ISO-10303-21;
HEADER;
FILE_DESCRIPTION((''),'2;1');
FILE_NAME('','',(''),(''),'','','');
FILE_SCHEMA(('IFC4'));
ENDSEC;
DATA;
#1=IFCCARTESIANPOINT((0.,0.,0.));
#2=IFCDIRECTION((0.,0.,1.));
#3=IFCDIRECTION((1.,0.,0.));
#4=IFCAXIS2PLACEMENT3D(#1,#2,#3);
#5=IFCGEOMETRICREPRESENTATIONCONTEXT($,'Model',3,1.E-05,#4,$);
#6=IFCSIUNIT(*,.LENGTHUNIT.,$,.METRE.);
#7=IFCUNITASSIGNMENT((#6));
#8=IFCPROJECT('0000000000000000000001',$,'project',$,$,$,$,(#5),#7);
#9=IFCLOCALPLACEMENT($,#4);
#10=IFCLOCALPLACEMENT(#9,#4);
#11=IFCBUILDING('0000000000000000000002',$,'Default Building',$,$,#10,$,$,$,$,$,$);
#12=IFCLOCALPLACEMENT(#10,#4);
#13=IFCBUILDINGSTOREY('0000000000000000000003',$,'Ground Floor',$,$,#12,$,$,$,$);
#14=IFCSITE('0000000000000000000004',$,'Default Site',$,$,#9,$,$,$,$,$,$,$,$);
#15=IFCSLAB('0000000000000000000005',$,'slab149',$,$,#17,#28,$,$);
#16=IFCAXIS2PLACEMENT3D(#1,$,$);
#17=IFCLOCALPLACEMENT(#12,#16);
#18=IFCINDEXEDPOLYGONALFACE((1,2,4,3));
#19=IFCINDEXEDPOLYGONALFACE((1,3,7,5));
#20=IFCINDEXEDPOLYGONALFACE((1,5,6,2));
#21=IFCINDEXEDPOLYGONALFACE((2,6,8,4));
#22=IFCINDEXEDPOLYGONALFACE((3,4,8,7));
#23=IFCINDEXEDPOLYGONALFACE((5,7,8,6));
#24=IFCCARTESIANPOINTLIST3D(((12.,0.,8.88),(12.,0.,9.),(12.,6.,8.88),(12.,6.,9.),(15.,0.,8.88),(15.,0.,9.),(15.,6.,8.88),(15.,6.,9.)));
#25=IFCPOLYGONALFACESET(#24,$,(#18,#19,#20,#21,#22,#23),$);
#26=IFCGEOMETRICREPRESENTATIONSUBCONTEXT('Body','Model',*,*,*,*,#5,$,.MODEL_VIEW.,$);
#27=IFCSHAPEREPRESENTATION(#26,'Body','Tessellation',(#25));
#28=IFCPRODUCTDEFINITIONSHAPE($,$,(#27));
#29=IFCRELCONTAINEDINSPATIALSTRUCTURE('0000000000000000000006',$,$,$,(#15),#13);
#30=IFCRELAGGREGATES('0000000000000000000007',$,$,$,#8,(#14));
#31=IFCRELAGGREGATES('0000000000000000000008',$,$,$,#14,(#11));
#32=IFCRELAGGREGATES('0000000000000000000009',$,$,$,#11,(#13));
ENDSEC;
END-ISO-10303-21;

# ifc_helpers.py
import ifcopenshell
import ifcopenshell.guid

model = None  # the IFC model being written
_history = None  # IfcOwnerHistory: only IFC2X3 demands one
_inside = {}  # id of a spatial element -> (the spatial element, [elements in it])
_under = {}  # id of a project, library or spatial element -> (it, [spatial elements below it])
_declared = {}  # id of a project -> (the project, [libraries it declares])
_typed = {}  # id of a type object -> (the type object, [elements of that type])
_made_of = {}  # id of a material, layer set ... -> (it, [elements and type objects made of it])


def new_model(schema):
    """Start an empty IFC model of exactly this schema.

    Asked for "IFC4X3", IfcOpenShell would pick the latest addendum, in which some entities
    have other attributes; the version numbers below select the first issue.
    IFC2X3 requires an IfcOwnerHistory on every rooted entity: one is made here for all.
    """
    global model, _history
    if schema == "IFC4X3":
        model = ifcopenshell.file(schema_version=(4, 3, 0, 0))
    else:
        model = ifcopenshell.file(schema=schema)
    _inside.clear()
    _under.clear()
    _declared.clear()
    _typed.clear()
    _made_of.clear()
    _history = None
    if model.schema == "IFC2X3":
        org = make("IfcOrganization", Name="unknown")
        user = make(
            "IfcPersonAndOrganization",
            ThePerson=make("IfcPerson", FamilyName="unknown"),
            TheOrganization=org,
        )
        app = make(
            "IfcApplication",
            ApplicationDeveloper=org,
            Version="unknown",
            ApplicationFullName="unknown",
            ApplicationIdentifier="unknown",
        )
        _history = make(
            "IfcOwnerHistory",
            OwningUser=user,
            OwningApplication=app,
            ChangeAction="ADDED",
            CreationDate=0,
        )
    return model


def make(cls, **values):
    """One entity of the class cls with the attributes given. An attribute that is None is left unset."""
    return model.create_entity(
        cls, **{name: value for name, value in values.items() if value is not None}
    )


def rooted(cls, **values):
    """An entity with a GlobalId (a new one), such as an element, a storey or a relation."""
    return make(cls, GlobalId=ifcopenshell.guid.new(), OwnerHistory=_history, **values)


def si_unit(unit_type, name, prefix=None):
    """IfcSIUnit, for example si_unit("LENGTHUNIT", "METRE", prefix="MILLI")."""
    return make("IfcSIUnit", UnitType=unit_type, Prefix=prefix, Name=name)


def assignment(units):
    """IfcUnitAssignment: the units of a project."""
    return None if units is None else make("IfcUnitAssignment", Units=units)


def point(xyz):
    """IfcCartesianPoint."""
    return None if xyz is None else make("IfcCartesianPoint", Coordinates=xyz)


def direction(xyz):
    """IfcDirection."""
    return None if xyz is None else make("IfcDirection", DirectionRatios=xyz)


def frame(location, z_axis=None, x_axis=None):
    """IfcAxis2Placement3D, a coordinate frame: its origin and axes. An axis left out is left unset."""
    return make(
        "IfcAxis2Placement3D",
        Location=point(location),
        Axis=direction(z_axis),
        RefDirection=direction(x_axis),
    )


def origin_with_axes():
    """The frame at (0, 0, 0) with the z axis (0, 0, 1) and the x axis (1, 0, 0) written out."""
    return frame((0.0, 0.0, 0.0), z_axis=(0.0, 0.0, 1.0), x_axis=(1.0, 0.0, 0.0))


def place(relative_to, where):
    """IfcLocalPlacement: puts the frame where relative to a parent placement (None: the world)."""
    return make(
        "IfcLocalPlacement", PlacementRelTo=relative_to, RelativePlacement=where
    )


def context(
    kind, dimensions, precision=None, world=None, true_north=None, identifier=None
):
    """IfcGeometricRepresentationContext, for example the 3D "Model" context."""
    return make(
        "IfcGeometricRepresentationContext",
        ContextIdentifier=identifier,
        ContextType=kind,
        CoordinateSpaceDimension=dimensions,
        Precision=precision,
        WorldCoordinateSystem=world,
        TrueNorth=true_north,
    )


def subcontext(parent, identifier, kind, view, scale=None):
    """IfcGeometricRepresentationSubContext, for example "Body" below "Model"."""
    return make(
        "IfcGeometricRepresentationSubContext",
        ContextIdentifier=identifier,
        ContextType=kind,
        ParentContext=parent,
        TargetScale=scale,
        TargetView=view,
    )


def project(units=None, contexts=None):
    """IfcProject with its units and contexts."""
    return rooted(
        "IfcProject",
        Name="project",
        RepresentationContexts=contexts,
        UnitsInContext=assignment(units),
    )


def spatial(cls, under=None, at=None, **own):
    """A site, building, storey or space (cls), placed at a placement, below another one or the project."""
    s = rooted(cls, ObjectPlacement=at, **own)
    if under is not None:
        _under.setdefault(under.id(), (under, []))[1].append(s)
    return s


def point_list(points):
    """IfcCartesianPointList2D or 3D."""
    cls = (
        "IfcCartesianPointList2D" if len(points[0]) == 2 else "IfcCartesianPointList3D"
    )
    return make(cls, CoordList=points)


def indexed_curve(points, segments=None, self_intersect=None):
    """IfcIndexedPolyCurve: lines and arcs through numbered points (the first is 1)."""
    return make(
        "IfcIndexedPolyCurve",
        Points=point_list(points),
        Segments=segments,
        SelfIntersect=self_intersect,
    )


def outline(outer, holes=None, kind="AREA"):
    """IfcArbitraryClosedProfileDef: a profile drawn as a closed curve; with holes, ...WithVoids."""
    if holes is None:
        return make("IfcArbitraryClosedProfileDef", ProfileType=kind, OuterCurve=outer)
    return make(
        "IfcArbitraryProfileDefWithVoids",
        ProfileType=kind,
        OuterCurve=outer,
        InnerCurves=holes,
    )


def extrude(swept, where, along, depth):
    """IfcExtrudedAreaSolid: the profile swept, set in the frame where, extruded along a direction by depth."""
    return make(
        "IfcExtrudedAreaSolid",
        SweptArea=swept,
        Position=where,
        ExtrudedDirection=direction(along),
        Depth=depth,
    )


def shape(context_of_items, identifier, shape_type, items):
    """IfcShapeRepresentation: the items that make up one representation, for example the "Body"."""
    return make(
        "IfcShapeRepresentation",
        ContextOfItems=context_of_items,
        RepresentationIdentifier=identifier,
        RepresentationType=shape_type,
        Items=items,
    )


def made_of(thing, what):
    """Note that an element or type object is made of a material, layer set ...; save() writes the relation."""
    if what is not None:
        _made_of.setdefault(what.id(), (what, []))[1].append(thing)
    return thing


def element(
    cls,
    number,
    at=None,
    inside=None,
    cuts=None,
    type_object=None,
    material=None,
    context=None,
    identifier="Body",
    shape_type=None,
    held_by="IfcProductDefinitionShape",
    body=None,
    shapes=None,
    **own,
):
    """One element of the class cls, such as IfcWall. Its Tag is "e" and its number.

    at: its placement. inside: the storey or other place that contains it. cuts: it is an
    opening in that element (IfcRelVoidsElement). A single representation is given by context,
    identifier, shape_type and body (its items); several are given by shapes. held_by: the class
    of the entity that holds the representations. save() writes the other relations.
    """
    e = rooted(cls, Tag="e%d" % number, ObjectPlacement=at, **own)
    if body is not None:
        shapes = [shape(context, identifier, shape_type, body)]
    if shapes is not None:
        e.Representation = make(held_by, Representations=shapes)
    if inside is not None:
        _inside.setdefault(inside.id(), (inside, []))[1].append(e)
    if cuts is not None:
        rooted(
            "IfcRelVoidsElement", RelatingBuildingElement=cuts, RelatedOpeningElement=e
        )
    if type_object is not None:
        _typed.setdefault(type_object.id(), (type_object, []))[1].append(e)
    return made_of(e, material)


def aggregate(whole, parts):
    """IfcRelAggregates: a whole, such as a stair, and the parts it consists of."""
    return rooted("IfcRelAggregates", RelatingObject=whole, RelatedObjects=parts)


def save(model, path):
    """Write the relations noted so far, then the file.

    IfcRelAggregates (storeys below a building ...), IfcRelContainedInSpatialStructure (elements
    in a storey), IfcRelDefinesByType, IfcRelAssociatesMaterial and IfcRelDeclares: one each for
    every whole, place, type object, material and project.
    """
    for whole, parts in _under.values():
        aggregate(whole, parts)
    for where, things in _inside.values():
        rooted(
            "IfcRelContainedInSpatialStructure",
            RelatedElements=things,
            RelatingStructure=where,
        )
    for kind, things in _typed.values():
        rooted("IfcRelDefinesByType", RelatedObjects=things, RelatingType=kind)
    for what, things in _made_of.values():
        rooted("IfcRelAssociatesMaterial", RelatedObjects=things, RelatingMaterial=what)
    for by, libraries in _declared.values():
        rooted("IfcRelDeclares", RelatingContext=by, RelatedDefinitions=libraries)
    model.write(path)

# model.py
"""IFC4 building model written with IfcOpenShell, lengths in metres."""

from ifc_helpers import new_model, si_unit, frame, origin_with_axes, place, context, subcontext, project, spatial, indexed_curve, outline, extrude, element, save


model = new_model("IFC4")

# Units and contexts
model_context = context("Model", 3, precision=1e-05, world=origin_with_axes())
body_context = subcontext(model_context, "Body", "Model", "MODEL_VIEW")
ifc_project = project(units=[si_unit("LENGTHUNIT", "METRE")], contexts=[model_context])

# Site, building, storey
site_placement = place(None, origin_with_axes())
site = spatial("IfcSite", under=ifc_project, at=site_placement, Name="Default Site")
building_placement = place(site_placement, origin_with_axes())
building = spatial("IfcBuilding", under=site, at=building_placement, Name="Default Building")
storey_placement = place(building_placement, origin_with_axes())
storey = spatial("IfcBuildingStorey", under=building, at=storey_placement, Name="Ground Floor")

# Slab
for number, where, z_axis, x_axis, name in (
    (1, (12.0, 0.0, 8.88), (0.0, 0.0, 1.0), (1.0, 0.0, 0.0), "slab149"),
):
    element("IfcSlab", number, at=place(storey_placement, frame(where, z_axis=z_axis, x_axis=x_axis)), inside=storey, Name=name, context=body_context, shape_type="SweptSolid", body=[
        extrude(outline(indexed_curve([(0.0, 0.0), (0.0, 6.0), (3.0, 6.0), (3.0, 0.0), (0.0, 0.0)], self_intersect=False)), origin_with_axes(), (0.0, 0.0, 1.0), 0.12),
    ])

save(model, "model.ifc")
